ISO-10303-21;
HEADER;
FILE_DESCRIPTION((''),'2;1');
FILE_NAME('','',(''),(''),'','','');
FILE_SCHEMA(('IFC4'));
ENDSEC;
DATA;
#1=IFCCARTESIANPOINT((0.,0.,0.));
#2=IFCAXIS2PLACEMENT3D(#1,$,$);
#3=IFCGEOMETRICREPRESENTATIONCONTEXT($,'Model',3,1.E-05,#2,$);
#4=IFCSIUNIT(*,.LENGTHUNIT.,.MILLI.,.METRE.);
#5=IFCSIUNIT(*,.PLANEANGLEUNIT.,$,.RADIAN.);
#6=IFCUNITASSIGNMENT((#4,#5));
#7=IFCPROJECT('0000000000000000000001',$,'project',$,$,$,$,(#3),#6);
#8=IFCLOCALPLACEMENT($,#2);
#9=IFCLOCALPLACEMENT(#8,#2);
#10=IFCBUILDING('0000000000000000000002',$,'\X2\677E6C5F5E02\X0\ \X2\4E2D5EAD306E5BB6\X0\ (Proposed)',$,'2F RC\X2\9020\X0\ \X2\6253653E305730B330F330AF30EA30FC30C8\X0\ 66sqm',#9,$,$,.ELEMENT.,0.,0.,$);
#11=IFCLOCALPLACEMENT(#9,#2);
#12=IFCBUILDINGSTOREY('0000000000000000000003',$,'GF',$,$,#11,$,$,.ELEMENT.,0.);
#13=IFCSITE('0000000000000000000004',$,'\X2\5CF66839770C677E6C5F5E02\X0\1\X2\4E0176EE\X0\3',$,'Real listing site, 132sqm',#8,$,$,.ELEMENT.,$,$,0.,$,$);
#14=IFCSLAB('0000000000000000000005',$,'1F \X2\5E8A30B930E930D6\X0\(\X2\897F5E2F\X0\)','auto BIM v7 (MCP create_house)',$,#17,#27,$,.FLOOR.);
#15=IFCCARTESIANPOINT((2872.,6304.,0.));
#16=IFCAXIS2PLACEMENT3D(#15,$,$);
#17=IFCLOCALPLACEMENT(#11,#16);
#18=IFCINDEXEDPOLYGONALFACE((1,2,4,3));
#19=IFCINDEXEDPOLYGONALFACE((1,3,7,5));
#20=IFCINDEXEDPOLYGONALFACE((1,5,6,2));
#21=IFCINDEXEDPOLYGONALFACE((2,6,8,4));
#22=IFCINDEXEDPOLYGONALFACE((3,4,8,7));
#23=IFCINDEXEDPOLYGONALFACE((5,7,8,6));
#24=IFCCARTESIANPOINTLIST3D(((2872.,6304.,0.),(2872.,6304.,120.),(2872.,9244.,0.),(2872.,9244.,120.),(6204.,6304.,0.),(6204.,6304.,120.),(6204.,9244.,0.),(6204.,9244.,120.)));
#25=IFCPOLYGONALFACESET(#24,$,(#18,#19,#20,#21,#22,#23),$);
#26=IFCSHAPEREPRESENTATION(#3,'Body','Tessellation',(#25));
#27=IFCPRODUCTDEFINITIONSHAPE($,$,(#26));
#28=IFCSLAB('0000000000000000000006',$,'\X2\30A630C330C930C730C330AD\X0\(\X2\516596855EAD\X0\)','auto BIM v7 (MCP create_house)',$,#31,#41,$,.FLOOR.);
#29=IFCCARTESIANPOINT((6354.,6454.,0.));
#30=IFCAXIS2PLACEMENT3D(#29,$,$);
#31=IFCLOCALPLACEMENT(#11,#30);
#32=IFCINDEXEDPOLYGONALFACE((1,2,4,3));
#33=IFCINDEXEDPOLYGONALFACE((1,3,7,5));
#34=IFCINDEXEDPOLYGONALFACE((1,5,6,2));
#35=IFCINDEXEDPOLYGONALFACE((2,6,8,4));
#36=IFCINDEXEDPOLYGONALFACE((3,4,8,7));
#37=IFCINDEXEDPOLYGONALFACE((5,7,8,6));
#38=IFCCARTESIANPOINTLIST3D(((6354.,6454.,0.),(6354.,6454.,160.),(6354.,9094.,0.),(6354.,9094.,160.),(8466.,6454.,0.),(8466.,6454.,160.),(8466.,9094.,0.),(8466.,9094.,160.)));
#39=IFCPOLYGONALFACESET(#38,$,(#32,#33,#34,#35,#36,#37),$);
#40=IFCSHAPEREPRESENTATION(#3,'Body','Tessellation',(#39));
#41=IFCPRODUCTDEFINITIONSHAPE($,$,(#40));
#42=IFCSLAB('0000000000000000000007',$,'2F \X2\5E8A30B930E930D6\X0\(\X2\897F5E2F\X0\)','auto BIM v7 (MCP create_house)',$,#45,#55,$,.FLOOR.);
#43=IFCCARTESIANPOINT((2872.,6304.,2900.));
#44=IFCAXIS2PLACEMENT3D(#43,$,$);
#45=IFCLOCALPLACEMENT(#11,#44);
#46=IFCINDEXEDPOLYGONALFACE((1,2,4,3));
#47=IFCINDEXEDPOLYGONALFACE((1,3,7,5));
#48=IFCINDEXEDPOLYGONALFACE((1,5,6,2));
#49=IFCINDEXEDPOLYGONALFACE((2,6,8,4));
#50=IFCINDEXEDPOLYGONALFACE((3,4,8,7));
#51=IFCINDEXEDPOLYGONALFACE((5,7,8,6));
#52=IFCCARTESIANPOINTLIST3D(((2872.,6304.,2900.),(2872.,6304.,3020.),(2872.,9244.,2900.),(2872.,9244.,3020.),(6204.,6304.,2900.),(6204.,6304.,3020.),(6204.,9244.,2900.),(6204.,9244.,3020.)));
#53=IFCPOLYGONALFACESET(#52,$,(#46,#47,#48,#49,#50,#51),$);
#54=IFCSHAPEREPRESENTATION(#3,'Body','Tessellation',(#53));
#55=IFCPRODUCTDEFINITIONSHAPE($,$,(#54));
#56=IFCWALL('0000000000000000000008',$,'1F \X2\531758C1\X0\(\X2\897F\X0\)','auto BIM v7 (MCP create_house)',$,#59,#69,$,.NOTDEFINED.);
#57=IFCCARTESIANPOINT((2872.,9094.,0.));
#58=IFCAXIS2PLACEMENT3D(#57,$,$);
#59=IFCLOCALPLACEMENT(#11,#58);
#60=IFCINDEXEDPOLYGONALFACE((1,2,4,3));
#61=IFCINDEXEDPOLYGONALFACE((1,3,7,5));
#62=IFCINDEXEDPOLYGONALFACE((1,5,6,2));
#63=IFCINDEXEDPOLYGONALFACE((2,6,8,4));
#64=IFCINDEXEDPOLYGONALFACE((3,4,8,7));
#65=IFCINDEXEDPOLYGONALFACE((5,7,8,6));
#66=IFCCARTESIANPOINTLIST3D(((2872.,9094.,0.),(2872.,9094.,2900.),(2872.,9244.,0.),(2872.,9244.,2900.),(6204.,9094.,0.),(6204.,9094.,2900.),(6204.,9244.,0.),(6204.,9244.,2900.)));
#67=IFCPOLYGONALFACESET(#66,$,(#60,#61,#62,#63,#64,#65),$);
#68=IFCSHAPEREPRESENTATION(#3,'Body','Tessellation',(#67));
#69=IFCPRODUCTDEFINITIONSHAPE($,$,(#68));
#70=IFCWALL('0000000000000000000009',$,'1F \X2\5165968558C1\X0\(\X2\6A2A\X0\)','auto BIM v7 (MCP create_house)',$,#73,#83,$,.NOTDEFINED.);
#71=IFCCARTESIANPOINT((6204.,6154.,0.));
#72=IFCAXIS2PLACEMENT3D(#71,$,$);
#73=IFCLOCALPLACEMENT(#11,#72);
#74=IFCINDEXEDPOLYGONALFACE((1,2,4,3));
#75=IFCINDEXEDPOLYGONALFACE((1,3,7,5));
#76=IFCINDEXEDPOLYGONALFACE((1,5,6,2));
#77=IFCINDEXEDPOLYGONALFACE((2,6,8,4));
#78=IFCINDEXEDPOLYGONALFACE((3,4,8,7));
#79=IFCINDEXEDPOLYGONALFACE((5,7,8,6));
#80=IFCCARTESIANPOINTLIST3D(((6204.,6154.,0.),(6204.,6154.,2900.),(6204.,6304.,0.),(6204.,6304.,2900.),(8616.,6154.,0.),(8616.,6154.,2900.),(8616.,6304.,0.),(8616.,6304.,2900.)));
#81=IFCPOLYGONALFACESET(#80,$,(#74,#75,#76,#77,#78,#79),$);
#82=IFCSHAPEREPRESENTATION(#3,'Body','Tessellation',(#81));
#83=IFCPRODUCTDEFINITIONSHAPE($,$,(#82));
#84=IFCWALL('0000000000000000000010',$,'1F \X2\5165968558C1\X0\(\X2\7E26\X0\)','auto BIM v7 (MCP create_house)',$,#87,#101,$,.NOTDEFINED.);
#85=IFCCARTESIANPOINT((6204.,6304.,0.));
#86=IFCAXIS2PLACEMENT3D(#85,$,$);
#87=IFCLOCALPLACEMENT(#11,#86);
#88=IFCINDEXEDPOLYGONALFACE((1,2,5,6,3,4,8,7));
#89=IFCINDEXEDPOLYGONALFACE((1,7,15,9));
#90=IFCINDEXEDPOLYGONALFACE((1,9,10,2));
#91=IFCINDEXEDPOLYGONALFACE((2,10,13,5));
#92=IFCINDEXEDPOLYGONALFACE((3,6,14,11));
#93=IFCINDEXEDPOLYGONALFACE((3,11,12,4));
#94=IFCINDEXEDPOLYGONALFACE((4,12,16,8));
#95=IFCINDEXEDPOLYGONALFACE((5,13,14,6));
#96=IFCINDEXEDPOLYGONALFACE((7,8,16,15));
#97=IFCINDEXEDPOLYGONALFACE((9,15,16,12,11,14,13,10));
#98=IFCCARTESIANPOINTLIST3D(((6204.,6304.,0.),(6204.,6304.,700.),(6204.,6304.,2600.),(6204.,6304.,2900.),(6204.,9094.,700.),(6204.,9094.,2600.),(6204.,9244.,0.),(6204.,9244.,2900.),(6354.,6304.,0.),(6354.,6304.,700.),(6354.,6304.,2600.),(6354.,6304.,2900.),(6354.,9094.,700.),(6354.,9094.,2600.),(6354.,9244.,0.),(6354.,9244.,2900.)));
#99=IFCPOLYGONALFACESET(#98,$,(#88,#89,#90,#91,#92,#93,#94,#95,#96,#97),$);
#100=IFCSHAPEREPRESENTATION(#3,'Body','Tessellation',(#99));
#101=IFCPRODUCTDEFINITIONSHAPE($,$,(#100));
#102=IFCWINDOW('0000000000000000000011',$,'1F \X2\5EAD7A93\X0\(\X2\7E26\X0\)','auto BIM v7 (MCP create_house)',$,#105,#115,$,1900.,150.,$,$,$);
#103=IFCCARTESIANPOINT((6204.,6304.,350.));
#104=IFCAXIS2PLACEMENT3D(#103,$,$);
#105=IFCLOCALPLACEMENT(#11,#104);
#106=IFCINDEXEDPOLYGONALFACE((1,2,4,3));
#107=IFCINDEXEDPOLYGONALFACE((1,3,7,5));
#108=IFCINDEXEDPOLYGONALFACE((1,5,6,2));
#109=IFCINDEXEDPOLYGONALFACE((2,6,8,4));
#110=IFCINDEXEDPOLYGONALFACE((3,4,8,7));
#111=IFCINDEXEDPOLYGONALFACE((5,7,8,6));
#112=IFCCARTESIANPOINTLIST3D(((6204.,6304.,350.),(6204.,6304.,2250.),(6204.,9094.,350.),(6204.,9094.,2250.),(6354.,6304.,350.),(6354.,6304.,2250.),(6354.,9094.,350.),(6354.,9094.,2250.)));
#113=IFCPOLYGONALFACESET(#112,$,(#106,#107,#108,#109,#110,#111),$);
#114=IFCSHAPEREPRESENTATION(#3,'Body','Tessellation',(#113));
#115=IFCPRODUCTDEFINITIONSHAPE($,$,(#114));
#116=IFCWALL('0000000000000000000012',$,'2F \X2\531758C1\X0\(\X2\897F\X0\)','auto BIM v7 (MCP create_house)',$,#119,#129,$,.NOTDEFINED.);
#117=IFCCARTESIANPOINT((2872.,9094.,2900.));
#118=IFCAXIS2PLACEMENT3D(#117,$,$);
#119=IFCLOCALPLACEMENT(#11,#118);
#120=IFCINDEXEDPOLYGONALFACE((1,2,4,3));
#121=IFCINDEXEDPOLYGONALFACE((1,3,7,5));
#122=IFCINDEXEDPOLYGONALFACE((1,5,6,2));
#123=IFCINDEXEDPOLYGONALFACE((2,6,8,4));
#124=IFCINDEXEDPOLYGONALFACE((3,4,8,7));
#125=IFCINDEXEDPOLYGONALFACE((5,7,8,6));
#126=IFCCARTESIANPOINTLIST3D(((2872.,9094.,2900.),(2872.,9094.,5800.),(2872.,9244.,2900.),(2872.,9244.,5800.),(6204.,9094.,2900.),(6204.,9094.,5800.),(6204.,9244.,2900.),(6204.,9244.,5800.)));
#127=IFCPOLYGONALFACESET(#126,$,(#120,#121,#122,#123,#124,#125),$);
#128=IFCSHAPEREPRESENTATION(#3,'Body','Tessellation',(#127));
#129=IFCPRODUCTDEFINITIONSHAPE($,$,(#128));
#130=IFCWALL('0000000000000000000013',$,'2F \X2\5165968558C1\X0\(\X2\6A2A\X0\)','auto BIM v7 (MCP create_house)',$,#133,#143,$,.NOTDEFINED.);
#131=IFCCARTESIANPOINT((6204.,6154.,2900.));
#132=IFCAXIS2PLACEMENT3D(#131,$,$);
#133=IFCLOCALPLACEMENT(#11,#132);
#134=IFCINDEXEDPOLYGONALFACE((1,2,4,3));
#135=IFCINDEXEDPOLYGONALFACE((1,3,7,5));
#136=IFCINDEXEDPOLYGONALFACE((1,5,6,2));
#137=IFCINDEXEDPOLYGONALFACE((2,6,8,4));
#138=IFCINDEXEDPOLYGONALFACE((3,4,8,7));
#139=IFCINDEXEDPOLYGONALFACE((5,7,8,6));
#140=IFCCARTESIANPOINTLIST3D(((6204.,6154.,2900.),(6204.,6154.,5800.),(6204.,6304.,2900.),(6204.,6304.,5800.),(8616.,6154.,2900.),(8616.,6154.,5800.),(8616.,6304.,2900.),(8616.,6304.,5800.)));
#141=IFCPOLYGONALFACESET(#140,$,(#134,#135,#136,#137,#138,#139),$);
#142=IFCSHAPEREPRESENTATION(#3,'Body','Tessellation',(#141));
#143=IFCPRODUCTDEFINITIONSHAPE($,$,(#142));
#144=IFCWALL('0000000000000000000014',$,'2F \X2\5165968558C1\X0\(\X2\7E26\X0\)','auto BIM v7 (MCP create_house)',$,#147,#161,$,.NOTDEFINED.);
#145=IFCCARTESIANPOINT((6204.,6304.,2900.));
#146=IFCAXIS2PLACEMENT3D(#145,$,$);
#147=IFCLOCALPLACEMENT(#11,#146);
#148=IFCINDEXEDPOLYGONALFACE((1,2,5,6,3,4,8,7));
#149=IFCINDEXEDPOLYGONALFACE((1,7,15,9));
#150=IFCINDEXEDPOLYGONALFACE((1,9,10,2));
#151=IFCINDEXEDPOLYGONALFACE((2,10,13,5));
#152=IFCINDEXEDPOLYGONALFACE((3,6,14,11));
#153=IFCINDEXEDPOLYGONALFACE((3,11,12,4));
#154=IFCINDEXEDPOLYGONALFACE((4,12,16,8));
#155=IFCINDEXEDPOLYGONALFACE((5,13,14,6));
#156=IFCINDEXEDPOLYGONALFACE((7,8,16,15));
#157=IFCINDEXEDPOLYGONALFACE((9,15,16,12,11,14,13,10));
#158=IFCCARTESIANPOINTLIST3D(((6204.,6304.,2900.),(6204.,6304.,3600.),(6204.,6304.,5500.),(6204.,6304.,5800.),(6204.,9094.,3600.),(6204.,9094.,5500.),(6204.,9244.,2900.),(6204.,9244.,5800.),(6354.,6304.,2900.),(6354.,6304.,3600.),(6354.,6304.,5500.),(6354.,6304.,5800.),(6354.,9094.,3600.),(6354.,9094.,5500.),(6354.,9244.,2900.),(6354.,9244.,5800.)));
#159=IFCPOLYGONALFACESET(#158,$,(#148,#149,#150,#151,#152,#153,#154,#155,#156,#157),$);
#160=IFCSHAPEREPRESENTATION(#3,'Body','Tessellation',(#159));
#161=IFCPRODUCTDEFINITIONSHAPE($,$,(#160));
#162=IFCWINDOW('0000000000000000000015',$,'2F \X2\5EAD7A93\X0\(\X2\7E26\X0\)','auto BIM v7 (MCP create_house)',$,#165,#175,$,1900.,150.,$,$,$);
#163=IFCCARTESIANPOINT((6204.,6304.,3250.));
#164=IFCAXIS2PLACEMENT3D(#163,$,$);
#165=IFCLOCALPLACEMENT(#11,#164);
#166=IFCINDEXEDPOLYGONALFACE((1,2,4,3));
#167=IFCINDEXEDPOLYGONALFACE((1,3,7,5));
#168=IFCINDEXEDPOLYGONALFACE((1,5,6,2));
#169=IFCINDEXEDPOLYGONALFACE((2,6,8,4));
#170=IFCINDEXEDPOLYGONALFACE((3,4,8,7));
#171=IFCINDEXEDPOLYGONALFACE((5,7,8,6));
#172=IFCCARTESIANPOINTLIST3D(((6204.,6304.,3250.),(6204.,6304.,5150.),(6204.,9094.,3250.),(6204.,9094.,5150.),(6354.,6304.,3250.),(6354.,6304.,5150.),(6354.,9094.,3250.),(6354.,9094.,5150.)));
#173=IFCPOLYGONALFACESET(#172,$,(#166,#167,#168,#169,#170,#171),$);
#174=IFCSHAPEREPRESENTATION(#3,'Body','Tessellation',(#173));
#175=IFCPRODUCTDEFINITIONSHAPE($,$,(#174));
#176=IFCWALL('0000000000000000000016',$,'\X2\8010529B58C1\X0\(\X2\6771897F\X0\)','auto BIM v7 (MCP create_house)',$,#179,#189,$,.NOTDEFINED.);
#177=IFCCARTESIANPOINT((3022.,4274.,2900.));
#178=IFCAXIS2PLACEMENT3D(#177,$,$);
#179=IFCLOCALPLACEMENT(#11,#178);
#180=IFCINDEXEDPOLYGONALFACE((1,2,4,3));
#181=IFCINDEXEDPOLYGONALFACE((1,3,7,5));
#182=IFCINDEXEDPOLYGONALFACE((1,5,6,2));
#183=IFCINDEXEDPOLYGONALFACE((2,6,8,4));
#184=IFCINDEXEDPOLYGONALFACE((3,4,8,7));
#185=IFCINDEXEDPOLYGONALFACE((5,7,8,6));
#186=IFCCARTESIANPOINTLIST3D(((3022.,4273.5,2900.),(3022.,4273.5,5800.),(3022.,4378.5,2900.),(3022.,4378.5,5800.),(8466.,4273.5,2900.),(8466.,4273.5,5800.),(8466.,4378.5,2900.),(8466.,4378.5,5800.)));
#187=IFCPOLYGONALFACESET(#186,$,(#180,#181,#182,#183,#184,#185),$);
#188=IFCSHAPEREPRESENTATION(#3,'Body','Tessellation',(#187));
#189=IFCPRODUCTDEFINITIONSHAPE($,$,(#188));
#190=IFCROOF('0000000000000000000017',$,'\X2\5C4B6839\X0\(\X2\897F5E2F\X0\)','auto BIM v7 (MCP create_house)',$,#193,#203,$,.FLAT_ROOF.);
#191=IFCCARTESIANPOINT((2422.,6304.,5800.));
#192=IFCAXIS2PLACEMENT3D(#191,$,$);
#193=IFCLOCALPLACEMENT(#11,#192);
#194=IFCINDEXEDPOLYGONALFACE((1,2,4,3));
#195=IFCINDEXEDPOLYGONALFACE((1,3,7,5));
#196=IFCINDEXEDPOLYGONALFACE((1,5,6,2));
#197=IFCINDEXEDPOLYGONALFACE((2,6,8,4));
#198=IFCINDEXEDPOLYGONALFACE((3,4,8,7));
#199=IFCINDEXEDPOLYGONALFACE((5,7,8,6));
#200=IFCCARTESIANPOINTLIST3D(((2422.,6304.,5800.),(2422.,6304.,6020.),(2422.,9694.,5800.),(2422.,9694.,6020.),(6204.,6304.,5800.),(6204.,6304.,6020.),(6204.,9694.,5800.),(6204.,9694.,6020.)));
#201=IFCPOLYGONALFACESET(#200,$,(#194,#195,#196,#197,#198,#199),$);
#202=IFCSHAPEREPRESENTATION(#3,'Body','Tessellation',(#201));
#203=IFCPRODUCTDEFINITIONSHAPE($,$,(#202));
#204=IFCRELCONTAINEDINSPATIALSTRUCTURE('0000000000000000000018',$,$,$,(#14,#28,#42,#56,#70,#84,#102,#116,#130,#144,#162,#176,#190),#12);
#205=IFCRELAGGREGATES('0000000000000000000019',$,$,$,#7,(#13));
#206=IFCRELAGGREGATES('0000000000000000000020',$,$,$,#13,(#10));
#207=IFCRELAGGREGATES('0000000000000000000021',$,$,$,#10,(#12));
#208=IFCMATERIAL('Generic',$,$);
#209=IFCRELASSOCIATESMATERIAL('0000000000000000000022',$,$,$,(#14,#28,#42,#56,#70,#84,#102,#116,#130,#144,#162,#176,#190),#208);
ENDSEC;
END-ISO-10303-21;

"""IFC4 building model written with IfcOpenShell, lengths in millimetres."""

from ifc_helpers import new_model, si_unit, frame, frame_2d, origin, place, context, project, spatial, rectangle, extrude, material, element, fill, save


model = new_model("IFC4")

# Units and contexts
model_context = context("Model", 3, precision=1e-05, world=origin())
ifc_project = project(units=[si_unit("LENGTHUNIT", "METRE", prefix="MILLI"), si_unit("PLANEANGLEUNIT", "RADIAN")], contexts=[model_context])

# Site, building, storey
site_placement = place(None, origin())
site = spatial("IfcSite", under=ifc_project, at=site_placement, Name="島根県松江市1丁目3", ObjectType="Real listing site, 132sqm", CompositionType="ELEMENT", RefElevation=0.0)
building_placement = place(site_placement, origin())
building = spatial("IfcBuilding", under=site, at=building_placement, Name="松江市 中庭の家 (Proposed)", ObjectType="2F RC造 打放しコンクリート 66sqm", CompositionType="ELEMENT", ElevationOfRefHeight=0.0, ElevationOfTerrain=0.0)
storey_placement = place(building_placement, origin())
storey = spatial("IfcBuildingStorey", under=building, at=storey_placement, Name="GF", CompositionType="ELEMENT", Elevation=0.0)

# Slabs
ifc_material = material(Name="Generic")
slab_1_placement = place(storey_placement, frame((2872.0, 6304.0, 0.0)))
element("IfcSlab", 1, at=slab_1_placement, inside=storey, material=ifc_material, Name="1F 床スラブ(西帯)", Description="auto BIM v7 (MCP create_house)", PredefinedType="FLOOR", context=model_context, shape_type="SweptSolid", body=[
    extrude(rectangle(XDim=3332.0, YDim=2940.0, at=frame_2d((1666.0, 1470.0))), frame((2872.0, 6304.0, 0.0)), (0.0, 0.0, 1.0), 120.0),
])
slab_2_placement = place(storey_placement, frame((6354.0, 6454.0, 0.0)))
element("IfcSlab", 2, at=slab_2_placement, inside=storey, material=ifc_material, Name="ウッドデッキ(入隅庭)", Description="auto BIM v7 (MCP create_house)", PredefinedType="FLOOR", context=model_context, shape_type="SweptSolid", body=[
    extrude(rectangle(XDim=2112.0, YDim=2640.0, at=frame_2d((1056.0, 1320.0))), frame((6354.0, 6454.0, 0.0)), (0.0, 0.0, 1.0), 160.0),
])
slab_3_placement = place(storey_placement, frame((2872.0, 6304.0, 2900.0)))
element("IfcSlab", 3, at=slab_3_placement, inside=storey, material=ifc_material, Name="2F 床スラブ(西帯)", Description="auto BIM v7 (MCP create_house)", PredefinedType="FLOOR", context=model_context, shape_type="SweptSolid", body=[
    extrude(rectangle(XDim=3332.0, YDim=2940.0, at=frame_2d((1666.0, 1470.0))), frame((2872.0, 6304.0, 2900.0)), (0.0, 0.0, 1.0), 120.0),
])

# Walls
wall_1_placement = place(storey_placement, frame((2872.0, 9094.0, 0.0)))
element("IfcWall", 4, at=wall_1_placement, inside=storey, material=ifc_material, Name="1F 北壁(西)", Description="auto BIM v7 (MCP create_house)", PredefinedType="NOTDEFINED", context=model_context, shape_type="SweptSolid", body=[
    extrude(rectangle(XDim=3332.0, YDim=150.0, at=frame_2d((1666.0, 75.0))), frame((2872.0, 9094.0, 0.0)), (0.0, 0.0, 1.0), 2900.0),
])
wall_2_placement = place(storey_placement, frame((6204.0, 6154.0, 0.0)))
element("IfcWall", 5, at=wall_2_placement, inside=storey, material=ifc_material, Name="1F 入隅壁(横)", Description="auto BIM v7 (MCP create_house)", PredefinedType="NOTDEFINED", context=model_context, shape_type="SweptSolid", body=[
    extrude(rectangle(XDim=2412.0, YDim=150.0, at=frame_2d((1206.0, 75.0))), frame((6204.0, 6154.0, 0.0)), (0.0, 0.0, 1.0), 2900.0),
])

# Wall, opening, window
wall_3_placement = place(storey_placement, frame((6204.0, 6304.0, 0.0)))
wall_3 = element("IfcWall", 6, at=wall_3_placement, inside=storey, material=ifc_material, Name="1F 入隅壁(縦)", Description="auto BIM v7 (MCP create_house)", PredefinedType="NOTDEFINED", context=model_context, shape_type="SweptSolid", body=[
    extrude(rectangle(XDim=150.0, YDim=2940.0, at=frame_2d((75.0, 1470.0))), frame((6204.0, 6304.0, 0.0)), (0.0, 0.0, 1.0), 2900.0),
])
opening_1_placement = place(storey_placement, frame((6204.0, 6304.0, 350.0)))
opening_1 = element("IfcOpeningElement", 7, at=opening_1_placement, cuts=wall_3, PredefinedType="NOTDEFINED", context=model_context, shape_type="SweptSolid", body=[
    extrude(rectangle(XDim=150.0, YDim=2790.0, at=frame_2d((75.0, 1395.0))), frame((6204.0, 6304.0, 350.0)), (0.0, 0.0, 1.0), 1900.0),
])
window_1_placement = place(storey_placement, frame((6204.0, 6304.0, 350.0)))
window_1 = element("IfcWindow", 8, at=window_1_placement, inside=storey, material=ifc_material, Name="1F 庭窓(縦)", Description="auto BIM v7 (MCP create_house)", OverallHeight=1900.0, OverallWidth=150.0, context=model_context, shape_type="SweptSolid", body=[
    extrude(rectangle(XDim=150.0, YDim=2790.0, at=frame_2d((75.0, 1395.0))), frame((6204.0, 6304.0, 350.0)), (0.0, 0.0, 1.0), 1900.0),
])
fill(opening_1, window_1)

# Walls
wall_4_placement = place(storey_placement, frame((2872.0, 9094.0, 2900.0)))
element("IfcWall", 9, at=wall_4_placement, inside=storey, material=ifc_material, Name="2F 北壁(西)", Description="auto BIM v7 (MCP create_house)", PredefinedType="NOTDEFINED", context=model_context, shape_type="SweptSolid", body=[
    extrude(rectangle(XDim=3332.0, YDim=150.0, at=frame_2d((1666.0, 75.0))), frame((2872.0, 9094.0, 2900.0)), (0.0, 0.0, 1.0), 2900.0),
])
wall_5_placement = place(storey_placement, frame((6204.0, 6154.0, 2900.0)))
element("IfcWall", 10, at=wall_5_placement, inside=storey, material=ifc_material, Name="2F 入隅壁(横)", Description="auto BIM v7 (MCP create_house)", PredefinedType="NOTDEFINED", context=model_context, shape_type="SweptSolid", body=[
    extrude(rectangle(XDim=2412.0, YDim=150.0, at=frame_2d((1206.0, 75.0))), frame((6204.0, 6154.0, 2900.0)), (0.0, 0.0, 1.0), 2900.0),
])

# Wall, opening, window
wall_6_placement = place(storey_placement, frame((6204.0, 6304.0, 2900.0)))
wall_6 = element("IfcWall", 11, at=wall_6_placement, inside=storey, material=ifc_material, Name="2F 入隅壁(縦)", Description="auto BIM v7 (MCP create_house)", PredefinedType="NOTDEFINED", context=model_context, shape_type="SweptSolid", body=[
    extrude(rectangle(XDim=150.0, YDim=2940.0, at=frame_2d((75.0, 1470.0))), frame((6204.0, 6304.0, 2900.0)), (0.0, 0.0, 1.0), 2900.0),
])
opening_2_placement = place(storey_placement, frame((6204.0, 6304.0, 3250.0)))
opening_2 = element("IfcOpeningElement", 12, at=opening_2_placement, cuts=wall_6, PredefinedType="NOTDEFINED", context=model_context, shape_type="SweptSolid", body=[
    extrude(rectangle(XDim=150.0, YDim=2790.0, at=frame_2d((75.0, 1395.0))), frame((6204.0, 6304.0, 3250.0)), (0.0, 0.0, 1.0), 1900.0),
])
window_2_placement = place(storey_placement, frame((6204.0, 6304.0, 3250.0)))
window_2 = element("IfcWindow", 13, at=window_2_placement, inside=storey, material=ifc_material, Name="2F 庭窓(縦)", Description="auto BIM v7 (MCP create_house)", OverallHeight=1900.0, OverallWidth=150.0, context=model_context, shape_type="SweptSolid", body=[
    extrude(rectangle(XDim=150.0, YDim=2790.0, at=frame_2d((75.0, 1395.0))), frame((6204.0, 6304.0, 3250.0)), (0.0, 0.0, 1.0), 1900.0),
])
fill(opening_2, window_2)

# Wall
wall_7_placement = place(storey_placement, frame((3022.0, 4274.0, 2900.0)))
element("IfcWall", 14, at=wall_7_placement, inside=storey, material=ifc_material, Name="耐力壁(東西)", Description="auto BIM v7 (MCP create_house)", PredefinedType="NOTDEFINED", context=model_context, shape_type="SweptSolid", body=[
    extrude(rectangle(XDim=5444.0, YDim=105.0, at=frame_2d((2722.0, 52.0))), frame((3022.0, 4274.0, 2900.0)), (0.0, 0.0, 1.0), 2900.0),
])

# Roof
for number, where, name in (
    (15, (2422.0, 6304.0, 5800.0), "屋根(西帯)"),
):
    element("IfcRoof", number, at=place(storey_placement, frame(where)), inside=storey, material=ifc_material, Name=name, Description="auto BIM v7 (MCP create_house)", PredefinedType="FLAT_ROOF", context=model_context, shape_type="SweptSolid", body=[
        extrude(rectangle(XDim=3782.0, YDim=3390.0, at=frame_2d((1891.0, 1695.0))), frame((2422.0, 6304.0, 5800.0)), (0.0, 0.0, 1.0), 220.0),
    ])

save(model, "model.ifc")
